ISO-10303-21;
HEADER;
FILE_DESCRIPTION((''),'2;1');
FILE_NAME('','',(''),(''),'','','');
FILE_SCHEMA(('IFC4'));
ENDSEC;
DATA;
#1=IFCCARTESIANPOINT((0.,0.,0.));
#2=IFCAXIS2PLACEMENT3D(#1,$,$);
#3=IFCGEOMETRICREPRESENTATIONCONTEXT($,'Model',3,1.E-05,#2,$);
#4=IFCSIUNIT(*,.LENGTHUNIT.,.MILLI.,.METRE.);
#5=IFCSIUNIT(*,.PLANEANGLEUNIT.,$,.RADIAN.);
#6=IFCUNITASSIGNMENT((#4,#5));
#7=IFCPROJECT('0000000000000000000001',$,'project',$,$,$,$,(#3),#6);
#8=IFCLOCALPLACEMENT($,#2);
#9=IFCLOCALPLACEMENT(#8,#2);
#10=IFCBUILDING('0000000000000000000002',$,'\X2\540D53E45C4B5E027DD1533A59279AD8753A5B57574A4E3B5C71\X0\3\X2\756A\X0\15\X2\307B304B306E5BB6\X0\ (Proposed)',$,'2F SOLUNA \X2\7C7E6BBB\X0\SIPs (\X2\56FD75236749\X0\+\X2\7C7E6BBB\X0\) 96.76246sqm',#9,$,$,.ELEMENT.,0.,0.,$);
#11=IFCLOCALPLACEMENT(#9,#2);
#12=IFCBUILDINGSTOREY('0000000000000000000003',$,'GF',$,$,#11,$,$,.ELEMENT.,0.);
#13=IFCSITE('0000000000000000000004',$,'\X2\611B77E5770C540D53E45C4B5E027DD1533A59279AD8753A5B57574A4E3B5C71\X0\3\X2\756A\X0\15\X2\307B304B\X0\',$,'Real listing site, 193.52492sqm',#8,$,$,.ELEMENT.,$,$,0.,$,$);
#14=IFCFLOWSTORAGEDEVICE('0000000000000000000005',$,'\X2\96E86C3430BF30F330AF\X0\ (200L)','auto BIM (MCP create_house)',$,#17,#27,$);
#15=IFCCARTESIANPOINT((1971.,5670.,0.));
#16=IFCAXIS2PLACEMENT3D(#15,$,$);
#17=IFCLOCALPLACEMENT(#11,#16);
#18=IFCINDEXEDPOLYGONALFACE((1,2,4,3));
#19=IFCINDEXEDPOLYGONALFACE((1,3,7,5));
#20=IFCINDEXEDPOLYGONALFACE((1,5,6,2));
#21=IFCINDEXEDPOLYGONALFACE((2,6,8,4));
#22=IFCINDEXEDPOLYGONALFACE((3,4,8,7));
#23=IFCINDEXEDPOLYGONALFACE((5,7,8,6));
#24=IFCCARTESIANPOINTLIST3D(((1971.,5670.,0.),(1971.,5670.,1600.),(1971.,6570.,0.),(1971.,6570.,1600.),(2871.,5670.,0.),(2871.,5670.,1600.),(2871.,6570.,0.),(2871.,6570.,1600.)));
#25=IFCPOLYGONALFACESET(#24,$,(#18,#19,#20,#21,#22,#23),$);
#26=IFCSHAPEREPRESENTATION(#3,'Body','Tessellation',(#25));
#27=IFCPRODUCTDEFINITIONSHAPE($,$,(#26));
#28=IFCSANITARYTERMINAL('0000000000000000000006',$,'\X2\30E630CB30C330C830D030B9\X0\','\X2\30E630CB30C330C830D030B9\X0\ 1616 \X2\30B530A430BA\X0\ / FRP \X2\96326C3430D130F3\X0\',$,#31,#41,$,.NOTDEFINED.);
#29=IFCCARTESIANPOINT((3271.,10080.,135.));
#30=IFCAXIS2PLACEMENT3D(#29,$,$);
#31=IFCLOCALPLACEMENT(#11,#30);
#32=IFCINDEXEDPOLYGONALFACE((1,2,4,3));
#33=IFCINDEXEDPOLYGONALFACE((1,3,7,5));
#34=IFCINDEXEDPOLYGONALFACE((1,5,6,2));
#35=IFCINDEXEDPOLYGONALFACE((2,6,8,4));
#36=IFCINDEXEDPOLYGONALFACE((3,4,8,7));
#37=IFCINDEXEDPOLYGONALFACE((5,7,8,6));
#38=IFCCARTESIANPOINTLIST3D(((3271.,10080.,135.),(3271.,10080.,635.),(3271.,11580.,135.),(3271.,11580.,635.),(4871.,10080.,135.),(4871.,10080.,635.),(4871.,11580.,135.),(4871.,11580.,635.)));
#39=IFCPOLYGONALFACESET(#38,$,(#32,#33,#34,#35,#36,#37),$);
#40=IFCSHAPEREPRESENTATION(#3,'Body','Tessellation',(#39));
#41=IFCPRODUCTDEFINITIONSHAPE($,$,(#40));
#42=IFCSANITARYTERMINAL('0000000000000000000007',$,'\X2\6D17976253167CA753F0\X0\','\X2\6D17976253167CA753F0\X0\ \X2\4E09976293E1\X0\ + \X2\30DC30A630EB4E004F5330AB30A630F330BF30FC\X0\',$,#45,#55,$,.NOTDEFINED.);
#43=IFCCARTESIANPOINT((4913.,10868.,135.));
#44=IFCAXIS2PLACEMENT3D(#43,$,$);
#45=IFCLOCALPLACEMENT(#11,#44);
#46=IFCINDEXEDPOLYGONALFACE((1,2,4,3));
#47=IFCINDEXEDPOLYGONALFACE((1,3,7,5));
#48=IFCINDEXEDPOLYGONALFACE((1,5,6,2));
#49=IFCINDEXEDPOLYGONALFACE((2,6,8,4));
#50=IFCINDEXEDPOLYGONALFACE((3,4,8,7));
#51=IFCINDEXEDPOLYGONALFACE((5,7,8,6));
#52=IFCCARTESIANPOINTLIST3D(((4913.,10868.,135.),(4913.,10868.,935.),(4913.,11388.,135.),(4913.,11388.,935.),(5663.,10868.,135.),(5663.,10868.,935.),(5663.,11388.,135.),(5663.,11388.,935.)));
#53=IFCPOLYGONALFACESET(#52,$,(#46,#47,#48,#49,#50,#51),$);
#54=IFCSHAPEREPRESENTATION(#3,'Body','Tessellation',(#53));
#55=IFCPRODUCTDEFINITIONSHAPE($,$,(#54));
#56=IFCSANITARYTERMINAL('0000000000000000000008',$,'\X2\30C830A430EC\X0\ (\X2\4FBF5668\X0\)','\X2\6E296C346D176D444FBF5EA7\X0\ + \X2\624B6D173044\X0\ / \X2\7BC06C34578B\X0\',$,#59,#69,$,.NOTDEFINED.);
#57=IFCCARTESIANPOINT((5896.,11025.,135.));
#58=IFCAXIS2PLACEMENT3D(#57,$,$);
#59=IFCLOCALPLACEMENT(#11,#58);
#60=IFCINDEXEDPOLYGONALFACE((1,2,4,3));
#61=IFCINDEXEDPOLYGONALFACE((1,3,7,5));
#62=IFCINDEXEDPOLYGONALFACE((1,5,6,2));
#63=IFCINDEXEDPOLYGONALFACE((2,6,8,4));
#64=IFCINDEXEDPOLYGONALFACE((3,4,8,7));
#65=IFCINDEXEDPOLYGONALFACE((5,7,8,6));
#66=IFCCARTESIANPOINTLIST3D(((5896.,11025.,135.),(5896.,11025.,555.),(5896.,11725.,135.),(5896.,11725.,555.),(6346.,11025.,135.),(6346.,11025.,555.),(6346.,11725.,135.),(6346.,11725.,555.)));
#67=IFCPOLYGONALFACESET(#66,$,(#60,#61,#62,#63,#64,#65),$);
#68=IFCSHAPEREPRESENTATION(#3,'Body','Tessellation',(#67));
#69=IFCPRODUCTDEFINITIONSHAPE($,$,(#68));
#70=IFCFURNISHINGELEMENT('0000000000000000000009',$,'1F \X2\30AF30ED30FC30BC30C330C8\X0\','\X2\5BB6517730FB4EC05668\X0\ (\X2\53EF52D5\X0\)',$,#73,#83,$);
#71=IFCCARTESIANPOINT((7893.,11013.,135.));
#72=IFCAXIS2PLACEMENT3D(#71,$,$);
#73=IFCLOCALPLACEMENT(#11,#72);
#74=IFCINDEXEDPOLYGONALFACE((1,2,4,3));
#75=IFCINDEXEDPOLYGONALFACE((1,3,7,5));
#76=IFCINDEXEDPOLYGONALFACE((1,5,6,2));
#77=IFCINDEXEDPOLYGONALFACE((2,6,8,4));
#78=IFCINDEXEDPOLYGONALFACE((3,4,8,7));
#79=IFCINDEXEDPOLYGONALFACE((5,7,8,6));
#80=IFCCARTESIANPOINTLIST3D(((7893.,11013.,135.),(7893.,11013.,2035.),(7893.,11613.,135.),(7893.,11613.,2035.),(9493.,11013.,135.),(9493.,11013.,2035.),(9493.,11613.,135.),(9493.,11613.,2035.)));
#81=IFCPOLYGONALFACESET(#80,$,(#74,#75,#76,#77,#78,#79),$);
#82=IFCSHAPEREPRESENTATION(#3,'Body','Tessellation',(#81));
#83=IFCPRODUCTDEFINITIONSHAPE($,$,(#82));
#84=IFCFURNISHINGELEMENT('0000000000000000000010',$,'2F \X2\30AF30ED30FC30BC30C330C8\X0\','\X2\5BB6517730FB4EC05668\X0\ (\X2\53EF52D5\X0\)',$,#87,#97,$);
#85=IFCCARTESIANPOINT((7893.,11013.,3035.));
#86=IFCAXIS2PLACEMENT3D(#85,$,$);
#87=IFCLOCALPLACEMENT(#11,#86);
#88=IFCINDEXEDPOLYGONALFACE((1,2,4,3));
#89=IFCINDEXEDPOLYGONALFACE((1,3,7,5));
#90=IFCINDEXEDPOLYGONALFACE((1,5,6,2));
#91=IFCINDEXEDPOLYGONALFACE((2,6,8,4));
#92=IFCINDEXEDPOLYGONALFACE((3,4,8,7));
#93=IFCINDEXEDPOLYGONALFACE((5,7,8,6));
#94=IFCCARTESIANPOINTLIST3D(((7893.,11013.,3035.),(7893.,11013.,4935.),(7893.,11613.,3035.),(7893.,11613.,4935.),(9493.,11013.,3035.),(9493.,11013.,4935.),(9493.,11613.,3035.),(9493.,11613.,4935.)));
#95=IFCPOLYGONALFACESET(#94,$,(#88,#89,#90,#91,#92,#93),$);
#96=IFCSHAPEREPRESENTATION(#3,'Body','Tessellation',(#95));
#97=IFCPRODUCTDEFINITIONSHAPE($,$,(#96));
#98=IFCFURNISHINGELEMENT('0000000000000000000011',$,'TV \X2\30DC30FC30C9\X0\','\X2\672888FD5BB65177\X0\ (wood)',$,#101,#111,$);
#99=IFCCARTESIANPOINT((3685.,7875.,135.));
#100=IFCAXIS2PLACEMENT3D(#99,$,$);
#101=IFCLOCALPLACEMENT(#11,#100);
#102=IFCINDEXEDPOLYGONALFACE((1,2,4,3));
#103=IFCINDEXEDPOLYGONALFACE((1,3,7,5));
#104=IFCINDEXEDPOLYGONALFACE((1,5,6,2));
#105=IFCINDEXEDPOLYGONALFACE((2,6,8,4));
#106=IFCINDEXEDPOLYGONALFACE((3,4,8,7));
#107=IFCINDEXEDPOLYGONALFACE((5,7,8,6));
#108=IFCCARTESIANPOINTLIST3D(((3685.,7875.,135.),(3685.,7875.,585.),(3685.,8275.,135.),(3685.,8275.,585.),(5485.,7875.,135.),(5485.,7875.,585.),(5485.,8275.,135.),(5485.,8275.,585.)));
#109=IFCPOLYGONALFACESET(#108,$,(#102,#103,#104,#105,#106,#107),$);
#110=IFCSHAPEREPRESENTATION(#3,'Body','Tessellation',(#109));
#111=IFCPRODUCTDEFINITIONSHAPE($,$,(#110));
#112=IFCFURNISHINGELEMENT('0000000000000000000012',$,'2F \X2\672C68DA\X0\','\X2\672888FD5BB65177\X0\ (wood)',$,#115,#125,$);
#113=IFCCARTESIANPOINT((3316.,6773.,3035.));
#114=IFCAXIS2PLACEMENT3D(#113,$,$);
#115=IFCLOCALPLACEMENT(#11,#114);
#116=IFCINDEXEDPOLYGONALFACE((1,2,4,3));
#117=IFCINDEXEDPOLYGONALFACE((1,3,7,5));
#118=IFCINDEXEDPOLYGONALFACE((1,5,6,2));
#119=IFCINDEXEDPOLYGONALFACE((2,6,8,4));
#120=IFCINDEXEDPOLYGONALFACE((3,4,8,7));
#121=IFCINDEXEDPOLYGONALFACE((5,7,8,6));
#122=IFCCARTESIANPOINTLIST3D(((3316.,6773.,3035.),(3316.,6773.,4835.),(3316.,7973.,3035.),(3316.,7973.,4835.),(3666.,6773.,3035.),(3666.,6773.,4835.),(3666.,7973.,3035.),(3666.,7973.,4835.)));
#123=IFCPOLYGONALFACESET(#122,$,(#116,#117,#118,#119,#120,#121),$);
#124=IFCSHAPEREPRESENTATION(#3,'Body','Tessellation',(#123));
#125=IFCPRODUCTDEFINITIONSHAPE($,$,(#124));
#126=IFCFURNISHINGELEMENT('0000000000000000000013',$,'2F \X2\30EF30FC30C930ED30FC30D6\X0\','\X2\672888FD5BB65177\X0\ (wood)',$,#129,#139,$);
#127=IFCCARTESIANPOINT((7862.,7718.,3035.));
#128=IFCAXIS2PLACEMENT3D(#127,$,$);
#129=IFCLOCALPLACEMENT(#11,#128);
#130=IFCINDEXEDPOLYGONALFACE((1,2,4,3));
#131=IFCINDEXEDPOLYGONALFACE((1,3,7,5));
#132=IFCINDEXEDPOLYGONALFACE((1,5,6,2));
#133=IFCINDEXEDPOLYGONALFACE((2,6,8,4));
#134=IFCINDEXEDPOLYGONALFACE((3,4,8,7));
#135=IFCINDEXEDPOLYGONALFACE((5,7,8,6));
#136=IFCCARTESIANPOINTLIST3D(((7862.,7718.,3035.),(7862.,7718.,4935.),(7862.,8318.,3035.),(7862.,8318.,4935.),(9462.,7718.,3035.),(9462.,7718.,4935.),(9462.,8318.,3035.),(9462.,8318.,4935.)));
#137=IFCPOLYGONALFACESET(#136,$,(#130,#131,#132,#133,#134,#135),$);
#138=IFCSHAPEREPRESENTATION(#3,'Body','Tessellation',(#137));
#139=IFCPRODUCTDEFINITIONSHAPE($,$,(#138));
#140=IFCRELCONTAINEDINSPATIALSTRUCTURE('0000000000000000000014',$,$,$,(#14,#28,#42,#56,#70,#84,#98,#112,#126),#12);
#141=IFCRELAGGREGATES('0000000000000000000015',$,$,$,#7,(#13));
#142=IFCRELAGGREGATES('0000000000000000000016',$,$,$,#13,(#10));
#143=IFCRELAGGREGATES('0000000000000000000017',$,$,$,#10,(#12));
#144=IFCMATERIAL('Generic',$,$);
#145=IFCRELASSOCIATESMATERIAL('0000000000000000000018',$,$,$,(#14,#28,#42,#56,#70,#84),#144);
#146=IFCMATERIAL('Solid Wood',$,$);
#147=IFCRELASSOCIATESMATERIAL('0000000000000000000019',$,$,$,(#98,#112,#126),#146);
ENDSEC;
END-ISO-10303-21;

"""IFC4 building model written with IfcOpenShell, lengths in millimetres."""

from ifc_helpers import new_model, si_unit, frame, frame_2d, origin, place, context, project, spatial, rectangle, extrude, material, element, save


model = new_model("IFC4")

# Units and contexts
model_context = context("Model", 3, precision=1e-05, world=origin())
ifc_project = project(units=[si_unit("LENGTHUNIT", "METRE", prefix="MILLI"), si_unit("PLANEANGLEUNIT", "RADIAN")], contexts=[model_context])

# Site, building, storey
site_placement = place(None, origin())
site = spatial("IfcSite", under=ifc_project, at=site_placement, Name="愛知県名古屋市緑区大高町字坊主山3番15ほか", ObjectType="Real listing site, 193.52492sqm", CompositionType="ELEMENT", RefElevation=0.0)
building_placement = place(site_placement, origin())
building = spatial("IfcBuilding", under=site, at=building_placement, Name="名古屋市緑区大高町字坊主山3番15ほかの家 (Proposed)", ObjectType="2F SOLUNA 籾殻SIPs (国産杉+籾殻) 96.76246sqm", CompositionType="ELEMENT", ElevationOfRefHeight=0.0, ElevationOfTerrain=0.0)
storey_placement = place(building_placement, origin())
storey = spatial("IfcBuildingStorey", under=building, at=storey_placement, Name="GF", CompositionType="ELEMENT", Elevation=0.0)

# Shared definitions
ifc_material_1 = material(Name="Solid Wood")

# Flow storage device
ifc_material_2 = material(Name="Generic")
flow_storage_device_placement = place(storey_placement, frame((1971.0, 5670.0, 0.0)))
element("IfcFlowStorageDevice", 1, at=flow_storage_device_placement, inside=storey, material=ifc_material_2, Name="雨水タンク (200L)", Description="auto BIM (MCP create_house)", context=model_context, shape_type="SweptSolid", body=[
    extrude(rectangle(XDim=900.0, YDim=900.0, at=frame_2d((450.0, 450.0))), frame((1971.0, 5670.0, 0.0)), (0.0, 0.0, 1.0), 1600.0),
])

# Sanitary terminals
sanitary_terminal_1_placement = place(storey_placement, frame((3271.0, 10080.0, 135.0)))
element("IfcSanitaryTerminal", 2, at=sanitary_terminal_1_placement, inside=storey, material=ifc_material_2, Name="ユニットバス", Description="ユニットバス 1616 サイズ / FRP 防水パン", PredefinedType="NOTDEFINED", context=model_context, shape_type="SweptSolid", body=[
    extrude(rectangle(XDim=1600.0, YDim=1500.0, at=frame_2d((800.0, 750.0))), frame((3271.0, 10080.0, 135.0)), (0.0, 0.0, 1.0), 500.0),
])
sanitary_terminal_2_placement = place(storey_placement, frame((4913.0, 10868.0, 135.0)))
element("IfcSanitaryTerminal", 3, at=sanitary_terminal_2_placement, inside=storey, material=ifc_material_2, Name="洗面化粧台", Description="洗面化粧台 三面鏡 + ボウル一体カウンター", PredefinedType="NOTDEFINED", context=model_context, shape_type="SweptSolid", body=[
    extrude(rectangle(XDim=750.0, YDim=520.0, at=frame_2d((375.0, 260.0))), frame((4913.0, 10868.0, 135.0)), (0.0, 0.0, 1.0), 800.0),
])
sanitary_terminal_3_placement = place(storey_placement, frame((5896.0, 11025.0, 135.0)))
element("IfcSanitaryTerminal", 4, at=sanitary_terminal_3_placement, inside=storey, material=ifc_material_2, Name="トイレ (便器)", Description="温水洗浄便座 + 手洗い / 節水型", PredefinedType="NOTDEFINED", context=model_context, shape_type="SweptSolid", body=[
    extrude(rectangle(XDim=450.0, YDim=700.0, at=frame_2d((225.0, 350.0))), frame((5896.0, 11025.0, 135.0)), (0.0, 0.0, 1.0), 420.0),
])

# Furnishing elements
furnishing_1_placement = place(storey_placement, frame((7893.0, 11013.0, 135.0)))
element("IfcFurnishingElement", 5, at=furnishing_1_placement, inside=storey, material=ifc_material_2, Name="1F クローゼット", Description="家具・什器 (可動)", context=model_context, shape_type="SweptSolid", body=[
    extrude(rectangle(XDim=1600.0, YDim=600.0, at=frame_2d((800.0, 300.0))), frame((7893.0, 11013.0, 135.0)), (0.0, 0.0, 1.0), 1900.0),
])
furnishing_2_placement = place(storey_placement, frame((7893.0, 11013.0, 3035.0)))
element("IfcFurnishingElement", 6, at=furnishing_2_placement, inside=storey, material=ifc_material_2, Name="2F クローゼット", Description="家具・什器 (可動)", context=model_context, shape_type="SweptSolid", body=[
    extrude(rectangle(XDim=1600.0, YDim=600.0, at=frame_2d((800.0, 300.0))), frame((7893.0, 11013.0, 3035.0)), (0.0, 0.0, 1.0), 1900.0),
])
furnishing_3_placement = place(storey_placement, frame((3685.0, 7875.0, 135.0)))
element("IfcFurnishingElement", 7, at=furnishing_3_placement, inside=storey, material=ifc_material_1, Name="TV ボード", Description="木製家具 (wood)", context=model_context, shape_type="SweptSolid", body=[
    extrude(rectangle(XDim=1800.0, YDim=400.0, at=frame_2d((900.0, 200.0))), frame((3685.0, 7875.0, 135.0)), (0.0, 0.0, 1.0), 450.0),
])
furnishing_4_placement = place(storey_placement, frame((3316.0, 6773.0, 3035.0)))
element("IfcFurnishingElement", 8, at=furnishing_4_placement, inside=storey, material=ifc_material_1, Name="2F 本棚", Description="木製家具 (wood)", context=model_context, shape_type="SweptSolid", body=[
    extrude(rectangle(XDim=350.0, YDim=1200.0, at=frame_2d((175.0, 600.0))), frame((3316.0, 6773.0, 3035.0)), (0.0, 0.0, 1.0), 1800.0),
])
furnishing_5_placement = place(storey_placement, frame((7862.0, 7718.0, 3035.0)))
element("IfcFurnishingElement", 9, at=furnishing_5_placement, inside=storey, material=ifc_material_1, Name="2F ワードローブ", Description="木製家具 (wood)", context=model_context, shape_type="SweptSolid", body=[
    extrude(rectangle(XDim=1600.0, YDim=600.0, at=frame_2d((800.0, 300.0))), frame((7862.0, 7718.0, 3035.0)), (0.0, 0.0, 1.0), 1900.0),
])

save(model, "model.ifc")
